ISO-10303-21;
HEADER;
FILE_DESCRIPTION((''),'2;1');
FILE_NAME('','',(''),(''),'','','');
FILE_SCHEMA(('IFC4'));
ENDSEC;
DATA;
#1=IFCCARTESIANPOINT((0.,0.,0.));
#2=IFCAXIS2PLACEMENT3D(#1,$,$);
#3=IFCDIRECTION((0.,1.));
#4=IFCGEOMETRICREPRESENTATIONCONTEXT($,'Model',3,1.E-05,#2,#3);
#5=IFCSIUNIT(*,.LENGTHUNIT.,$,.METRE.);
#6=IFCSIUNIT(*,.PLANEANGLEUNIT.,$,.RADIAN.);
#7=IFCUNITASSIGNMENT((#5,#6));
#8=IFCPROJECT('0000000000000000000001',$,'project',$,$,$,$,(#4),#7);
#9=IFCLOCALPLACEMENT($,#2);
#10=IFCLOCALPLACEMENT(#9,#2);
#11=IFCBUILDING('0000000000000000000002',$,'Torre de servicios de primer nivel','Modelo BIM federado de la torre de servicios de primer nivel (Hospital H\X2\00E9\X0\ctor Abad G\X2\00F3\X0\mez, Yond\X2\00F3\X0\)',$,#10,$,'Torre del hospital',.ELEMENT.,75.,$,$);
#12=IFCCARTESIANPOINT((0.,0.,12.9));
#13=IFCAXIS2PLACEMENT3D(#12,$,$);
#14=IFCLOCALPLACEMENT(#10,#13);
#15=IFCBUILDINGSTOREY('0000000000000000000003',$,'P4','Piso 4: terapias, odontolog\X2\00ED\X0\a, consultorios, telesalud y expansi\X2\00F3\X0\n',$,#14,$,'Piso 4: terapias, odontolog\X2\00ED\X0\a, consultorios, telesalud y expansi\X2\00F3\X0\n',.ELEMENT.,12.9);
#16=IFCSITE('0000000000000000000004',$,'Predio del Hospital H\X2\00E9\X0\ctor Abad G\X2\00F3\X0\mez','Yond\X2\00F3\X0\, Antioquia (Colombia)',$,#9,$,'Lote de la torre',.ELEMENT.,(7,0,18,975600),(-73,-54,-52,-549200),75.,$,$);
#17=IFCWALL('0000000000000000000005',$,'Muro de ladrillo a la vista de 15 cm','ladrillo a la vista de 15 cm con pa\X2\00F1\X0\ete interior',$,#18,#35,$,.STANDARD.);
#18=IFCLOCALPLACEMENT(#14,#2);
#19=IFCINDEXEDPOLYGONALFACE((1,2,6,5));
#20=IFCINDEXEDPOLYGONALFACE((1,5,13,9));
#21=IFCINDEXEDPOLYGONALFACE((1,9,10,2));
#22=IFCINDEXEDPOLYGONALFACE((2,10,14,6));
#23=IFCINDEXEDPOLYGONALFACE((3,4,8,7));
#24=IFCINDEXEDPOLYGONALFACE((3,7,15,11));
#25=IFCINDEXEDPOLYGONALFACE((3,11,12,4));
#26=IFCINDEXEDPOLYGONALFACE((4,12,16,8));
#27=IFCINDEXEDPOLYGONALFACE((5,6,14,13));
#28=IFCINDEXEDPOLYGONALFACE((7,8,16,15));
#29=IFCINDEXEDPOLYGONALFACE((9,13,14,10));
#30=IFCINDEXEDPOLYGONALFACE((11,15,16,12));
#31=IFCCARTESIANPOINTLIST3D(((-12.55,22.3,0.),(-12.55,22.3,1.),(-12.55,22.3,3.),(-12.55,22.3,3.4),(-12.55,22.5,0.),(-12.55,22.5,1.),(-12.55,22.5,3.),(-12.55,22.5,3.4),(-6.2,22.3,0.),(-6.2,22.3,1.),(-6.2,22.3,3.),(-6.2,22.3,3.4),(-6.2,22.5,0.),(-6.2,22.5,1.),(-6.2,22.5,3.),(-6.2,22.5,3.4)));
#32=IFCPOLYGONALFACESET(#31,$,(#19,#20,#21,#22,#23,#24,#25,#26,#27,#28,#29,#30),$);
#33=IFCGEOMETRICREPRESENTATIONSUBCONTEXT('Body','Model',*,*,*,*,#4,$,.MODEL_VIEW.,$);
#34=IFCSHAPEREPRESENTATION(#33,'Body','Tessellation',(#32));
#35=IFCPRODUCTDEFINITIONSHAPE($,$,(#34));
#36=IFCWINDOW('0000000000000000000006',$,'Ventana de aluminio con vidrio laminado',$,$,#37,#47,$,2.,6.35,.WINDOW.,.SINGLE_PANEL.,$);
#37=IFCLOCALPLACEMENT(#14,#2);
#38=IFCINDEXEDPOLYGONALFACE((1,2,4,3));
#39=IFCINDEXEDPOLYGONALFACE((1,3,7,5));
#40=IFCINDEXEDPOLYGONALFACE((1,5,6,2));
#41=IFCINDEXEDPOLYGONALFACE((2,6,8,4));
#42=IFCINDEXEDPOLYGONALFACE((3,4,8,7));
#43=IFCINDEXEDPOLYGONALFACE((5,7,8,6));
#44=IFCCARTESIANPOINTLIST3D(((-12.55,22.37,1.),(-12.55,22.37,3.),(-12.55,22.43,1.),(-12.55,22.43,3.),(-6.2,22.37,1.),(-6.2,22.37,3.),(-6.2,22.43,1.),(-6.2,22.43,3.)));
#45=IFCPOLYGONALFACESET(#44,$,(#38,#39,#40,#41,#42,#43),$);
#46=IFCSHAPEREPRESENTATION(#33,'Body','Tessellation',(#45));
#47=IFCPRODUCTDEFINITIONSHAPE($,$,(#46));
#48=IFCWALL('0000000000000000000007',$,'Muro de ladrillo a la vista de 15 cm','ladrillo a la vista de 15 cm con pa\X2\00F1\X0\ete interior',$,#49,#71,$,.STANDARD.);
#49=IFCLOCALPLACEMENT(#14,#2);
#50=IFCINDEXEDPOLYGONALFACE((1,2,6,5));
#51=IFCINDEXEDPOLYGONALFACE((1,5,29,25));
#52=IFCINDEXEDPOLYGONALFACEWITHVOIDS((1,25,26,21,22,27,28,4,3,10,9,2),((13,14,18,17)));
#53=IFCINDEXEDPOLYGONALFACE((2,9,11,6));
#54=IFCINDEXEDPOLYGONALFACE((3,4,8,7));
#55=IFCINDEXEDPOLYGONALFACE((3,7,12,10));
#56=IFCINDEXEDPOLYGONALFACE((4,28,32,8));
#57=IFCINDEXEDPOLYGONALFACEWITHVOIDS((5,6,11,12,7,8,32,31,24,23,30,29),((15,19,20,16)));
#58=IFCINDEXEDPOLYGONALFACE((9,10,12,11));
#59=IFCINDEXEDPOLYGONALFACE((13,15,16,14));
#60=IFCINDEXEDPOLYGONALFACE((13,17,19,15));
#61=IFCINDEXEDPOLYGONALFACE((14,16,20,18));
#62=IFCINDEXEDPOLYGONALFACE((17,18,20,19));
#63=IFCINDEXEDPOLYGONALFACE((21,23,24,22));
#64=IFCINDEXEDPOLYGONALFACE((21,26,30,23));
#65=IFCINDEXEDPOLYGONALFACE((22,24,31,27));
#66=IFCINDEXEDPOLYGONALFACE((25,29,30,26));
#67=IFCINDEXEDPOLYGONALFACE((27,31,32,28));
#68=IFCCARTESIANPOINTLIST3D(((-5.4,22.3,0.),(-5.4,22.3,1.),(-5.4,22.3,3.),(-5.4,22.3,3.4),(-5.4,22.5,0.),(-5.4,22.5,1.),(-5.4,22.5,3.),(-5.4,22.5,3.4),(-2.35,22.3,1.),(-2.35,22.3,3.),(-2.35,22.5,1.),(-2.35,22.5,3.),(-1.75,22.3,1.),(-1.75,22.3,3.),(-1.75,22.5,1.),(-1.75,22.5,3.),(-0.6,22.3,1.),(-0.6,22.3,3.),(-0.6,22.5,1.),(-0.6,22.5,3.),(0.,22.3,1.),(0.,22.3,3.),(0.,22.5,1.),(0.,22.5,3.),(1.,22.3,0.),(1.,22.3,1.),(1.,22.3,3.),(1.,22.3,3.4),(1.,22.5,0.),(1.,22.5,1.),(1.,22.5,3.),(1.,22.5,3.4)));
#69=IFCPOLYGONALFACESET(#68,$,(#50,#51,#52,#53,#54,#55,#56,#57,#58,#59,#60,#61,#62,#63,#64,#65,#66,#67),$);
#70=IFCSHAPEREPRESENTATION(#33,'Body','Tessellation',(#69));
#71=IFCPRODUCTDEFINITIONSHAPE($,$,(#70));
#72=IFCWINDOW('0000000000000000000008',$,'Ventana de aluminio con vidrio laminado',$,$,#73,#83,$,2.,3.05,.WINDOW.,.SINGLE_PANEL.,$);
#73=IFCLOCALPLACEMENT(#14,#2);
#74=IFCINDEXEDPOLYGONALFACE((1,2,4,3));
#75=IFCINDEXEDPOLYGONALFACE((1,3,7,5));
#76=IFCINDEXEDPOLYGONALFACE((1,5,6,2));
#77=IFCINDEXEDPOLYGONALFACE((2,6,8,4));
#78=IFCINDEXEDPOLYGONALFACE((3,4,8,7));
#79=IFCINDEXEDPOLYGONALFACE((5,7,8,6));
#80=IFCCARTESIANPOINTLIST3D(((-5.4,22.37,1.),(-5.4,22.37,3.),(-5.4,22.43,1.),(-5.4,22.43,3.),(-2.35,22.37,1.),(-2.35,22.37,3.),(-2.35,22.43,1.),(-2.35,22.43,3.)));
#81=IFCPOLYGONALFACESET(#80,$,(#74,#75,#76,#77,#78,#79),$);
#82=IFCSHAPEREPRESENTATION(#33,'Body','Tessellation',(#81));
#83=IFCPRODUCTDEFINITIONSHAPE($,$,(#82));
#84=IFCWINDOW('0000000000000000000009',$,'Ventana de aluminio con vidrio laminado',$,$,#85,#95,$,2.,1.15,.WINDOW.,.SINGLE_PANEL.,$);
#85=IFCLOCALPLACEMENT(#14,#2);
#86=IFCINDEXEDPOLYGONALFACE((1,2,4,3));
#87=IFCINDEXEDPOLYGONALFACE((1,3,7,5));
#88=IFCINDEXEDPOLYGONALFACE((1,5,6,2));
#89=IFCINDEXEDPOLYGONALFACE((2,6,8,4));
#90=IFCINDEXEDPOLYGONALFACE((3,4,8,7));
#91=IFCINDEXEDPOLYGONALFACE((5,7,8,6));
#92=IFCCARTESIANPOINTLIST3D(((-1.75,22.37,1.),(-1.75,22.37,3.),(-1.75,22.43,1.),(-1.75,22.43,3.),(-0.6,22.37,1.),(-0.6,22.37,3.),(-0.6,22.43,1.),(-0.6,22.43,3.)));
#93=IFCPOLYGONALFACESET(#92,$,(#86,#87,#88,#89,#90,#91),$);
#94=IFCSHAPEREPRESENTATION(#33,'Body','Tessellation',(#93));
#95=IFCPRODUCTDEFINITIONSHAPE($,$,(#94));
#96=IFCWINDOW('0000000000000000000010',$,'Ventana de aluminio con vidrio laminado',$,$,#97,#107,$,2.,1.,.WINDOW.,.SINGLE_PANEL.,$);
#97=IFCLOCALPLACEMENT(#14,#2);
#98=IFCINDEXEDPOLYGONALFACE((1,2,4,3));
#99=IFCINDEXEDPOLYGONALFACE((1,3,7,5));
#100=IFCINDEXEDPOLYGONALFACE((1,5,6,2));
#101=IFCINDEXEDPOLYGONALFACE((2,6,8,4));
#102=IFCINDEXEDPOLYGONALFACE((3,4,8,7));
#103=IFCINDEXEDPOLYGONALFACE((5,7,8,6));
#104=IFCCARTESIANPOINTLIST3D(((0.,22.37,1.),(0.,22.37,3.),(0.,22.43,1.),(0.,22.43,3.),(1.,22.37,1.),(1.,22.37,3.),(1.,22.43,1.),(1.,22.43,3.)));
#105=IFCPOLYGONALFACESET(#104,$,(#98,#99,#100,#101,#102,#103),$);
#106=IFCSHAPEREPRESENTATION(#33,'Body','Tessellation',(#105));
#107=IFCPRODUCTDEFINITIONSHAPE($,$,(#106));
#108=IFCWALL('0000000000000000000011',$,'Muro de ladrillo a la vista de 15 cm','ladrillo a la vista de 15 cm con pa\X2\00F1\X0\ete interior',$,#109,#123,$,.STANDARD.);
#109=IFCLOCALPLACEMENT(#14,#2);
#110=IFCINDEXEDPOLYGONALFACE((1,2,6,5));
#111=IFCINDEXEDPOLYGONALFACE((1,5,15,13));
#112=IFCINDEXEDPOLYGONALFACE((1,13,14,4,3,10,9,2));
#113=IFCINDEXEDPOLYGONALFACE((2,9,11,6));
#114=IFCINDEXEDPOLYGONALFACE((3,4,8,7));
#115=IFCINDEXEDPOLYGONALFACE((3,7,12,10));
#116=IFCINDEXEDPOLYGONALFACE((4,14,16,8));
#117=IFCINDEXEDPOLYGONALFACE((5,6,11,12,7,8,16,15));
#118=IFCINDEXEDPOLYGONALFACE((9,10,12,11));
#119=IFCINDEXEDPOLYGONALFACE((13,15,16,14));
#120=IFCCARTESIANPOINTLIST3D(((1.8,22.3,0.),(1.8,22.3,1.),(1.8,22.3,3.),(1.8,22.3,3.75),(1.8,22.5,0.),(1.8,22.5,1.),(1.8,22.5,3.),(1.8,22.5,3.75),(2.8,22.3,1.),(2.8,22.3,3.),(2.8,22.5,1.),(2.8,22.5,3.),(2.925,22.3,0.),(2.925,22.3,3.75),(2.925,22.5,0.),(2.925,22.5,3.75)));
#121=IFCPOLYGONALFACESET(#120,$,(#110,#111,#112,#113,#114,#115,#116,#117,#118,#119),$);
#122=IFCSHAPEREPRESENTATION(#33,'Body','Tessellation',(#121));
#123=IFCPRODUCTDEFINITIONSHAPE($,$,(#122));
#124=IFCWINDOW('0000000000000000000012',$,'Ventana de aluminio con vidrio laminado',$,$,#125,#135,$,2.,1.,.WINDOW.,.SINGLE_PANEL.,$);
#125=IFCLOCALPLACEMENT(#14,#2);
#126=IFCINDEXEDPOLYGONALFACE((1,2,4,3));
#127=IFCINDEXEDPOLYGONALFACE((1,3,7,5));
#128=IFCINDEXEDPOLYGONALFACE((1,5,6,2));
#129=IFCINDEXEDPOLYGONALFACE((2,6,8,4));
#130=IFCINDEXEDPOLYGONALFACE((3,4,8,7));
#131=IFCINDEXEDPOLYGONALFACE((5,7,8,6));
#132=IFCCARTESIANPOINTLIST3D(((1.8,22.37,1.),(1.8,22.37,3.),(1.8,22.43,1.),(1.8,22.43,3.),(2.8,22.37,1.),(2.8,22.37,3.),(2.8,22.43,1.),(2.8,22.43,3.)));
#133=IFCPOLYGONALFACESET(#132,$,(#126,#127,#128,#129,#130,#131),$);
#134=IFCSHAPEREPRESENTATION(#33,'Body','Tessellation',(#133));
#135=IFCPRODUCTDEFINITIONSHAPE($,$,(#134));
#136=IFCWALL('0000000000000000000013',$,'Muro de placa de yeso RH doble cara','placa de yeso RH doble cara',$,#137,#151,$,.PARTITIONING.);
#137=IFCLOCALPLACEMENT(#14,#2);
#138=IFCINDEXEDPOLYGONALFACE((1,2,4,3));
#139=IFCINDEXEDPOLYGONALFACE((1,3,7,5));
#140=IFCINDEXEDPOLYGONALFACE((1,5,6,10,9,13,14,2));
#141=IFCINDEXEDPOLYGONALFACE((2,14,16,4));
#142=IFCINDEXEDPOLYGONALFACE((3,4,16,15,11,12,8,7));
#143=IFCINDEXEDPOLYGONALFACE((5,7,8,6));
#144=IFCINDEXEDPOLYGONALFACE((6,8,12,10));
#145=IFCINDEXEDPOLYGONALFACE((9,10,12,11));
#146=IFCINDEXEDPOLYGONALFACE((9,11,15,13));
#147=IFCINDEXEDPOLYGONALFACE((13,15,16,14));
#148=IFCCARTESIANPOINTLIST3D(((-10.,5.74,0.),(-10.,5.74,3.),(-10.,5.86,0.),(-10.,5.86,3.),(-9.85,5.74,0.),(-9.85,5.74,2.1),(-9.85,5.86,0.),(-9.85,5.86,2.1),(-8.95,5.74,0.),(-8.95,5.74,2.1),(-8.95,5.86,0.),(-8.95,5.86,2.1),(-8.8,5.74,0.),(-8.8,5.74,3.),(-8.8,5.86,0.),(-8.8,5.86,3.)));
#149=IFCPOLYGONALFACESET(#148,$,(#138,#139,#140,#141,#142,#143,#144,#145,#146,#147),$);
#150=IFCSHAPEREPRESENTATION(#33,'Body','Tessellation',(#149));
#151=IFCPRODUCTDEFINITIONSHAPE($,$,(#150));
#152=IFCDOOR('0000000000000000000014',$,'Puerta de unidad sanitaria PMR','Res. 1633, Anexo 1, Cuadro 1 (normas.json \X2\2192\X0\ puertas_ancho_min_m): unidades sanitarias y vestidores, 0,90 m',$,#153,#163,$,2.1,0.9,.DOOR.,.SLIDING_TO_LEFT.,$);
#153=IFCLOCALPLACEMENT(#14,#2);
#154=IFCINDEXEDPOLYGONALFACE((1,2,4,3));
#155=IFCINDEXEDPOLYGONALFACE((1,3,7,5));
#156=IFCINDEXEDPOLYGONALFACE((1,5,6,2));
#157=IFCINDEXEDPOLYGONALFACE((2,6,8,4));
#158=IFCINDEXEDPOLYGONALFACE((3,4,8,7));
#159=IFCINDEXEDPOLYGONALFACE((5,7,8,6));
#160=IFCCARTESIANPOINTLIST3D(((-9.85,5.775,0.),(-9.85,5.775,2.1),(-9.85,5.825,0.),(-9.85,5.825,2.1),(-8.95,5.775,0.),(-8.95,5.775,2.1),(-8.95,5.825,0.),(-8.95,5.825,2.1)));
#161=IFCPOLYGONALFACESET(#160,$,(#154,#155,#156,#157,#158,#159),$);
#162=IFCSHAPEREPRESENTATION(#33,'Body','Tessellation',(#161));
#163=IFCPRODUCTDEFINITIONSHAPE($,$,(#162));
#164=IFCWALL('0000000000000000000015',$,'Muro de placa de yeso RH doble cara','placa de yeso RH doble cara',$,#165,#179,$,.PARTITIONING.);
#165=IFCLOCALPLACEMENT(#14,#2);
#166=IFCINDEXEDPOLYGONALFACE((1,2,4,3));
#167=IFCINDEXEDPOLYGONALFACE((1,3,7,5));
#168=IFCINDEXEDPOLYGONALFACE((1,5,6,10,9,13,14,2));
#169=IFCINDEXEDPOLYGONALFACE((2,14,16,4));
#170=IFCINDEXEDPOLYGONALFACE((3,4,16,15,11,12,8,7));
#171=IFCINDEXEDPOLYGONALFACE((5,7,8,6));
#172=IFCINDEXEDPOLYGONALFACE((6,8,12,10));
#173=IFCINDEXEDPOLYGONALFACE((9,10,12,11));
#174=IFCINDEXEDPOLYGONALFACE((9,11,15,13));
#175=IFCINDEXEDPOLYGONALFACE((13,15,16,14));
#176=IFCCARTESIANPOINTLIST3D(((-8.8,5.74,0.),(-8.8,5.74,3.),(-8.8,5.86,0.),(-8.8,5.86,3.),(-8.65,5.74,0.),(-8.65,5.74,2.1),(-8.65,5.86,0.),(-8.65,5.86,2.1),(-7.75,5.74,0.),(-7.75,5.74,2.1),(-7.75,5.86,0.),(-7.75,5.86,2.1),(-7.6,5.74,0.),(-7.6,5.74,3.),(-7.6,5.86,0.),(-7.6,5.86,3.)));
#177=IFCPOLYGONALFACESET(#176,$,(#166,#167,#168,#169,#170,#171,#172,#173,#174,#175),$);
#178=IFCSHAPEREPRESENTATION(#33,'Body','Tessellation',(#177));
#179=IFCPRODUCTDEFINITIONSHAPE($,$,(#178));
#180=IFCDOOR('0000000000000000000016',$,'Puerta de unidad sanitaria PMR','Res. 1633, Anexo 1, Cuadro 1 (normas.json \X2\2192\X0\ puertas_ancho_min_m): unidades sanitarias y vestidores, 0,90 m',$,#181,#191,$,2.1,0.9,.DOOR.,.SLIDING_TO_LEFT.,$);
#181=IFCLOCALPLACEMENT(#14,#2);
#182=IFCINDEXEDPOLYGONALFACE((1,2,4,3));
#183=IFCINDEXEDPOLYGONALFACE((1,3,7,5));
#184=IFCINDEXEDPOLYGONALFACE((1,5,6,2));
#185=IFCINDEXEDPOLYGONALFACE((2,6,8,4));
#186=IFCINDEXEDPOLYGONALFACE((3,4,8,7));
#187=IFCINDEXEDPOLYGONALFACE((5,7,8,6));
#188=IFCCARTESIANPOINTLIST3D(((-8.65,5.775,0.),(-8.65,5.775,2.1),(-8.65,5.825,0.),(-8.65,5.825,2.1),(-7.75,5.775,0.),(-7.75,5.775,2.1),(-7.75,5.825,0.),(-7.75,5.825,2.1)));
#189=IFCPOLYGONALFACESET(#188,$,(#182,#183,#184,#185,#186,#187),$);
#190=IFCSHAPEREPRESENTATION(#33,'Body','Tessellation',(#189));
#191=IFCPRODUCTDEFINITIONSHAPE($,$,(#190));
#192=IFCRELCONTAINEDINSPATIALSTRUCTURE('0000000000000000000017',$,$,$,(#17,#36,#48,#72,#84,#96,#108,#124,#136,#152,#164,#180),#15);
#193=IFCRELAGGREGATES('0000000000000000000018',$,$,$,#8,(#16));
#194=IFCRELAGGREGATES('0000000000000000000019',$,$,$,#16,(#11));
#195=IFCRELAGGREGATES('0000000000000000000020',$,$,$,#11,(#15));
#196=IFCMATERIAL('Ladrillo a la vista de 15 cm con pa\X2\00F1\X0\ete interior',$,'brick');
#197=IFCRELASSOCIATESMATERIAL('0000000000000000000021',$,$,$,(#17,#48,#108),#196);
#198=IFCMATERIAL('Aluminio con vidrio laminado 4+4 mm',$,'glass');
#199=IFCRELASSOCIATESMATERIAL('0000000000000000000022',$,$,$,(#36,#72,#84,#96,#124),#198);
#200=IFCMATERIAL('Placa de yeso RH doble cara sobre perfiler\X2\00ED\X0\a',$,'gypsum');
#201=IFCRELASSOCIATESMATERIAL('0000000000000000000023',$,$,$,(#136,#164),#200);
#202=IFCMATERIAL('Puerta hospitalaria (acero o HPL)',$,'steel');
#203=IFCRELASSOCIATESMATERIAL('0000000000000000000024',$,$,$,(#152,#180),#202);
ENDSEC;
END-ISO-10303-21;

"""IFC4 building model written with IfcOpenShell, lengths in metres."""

from ifc_helpers import new_model, si_unit, direction, frame, origin, place, context, subcontext, project, spatial, rectangle, extrude, material, element, fill, save


model = new_model("IFC4")

# Units and contexts
model_context = context("Model", 3, precision=1e-05, world=origin(), true_north=direction((0.0, 1.0)))
body_context = subcontext(model_context, "Body", "Model", "MODEL_VIEW")
ifc_project = project(units=[si_unit("LENGTHUNIT", "METRE"), si_unit("PLANEANGLEUNIT", "RADIAN")], contexts=[model_context])

# Site, building, storey
site_placement = place(None, origin())
site = spatial("IfcSite", under=ifc_project, at=site_placement, Name="Predio del Hospital Héctor Abad Gómez", Description="Yondó, Antioquia (Colombia)", LongName="Lote de la torre", CompositionType="ELEMENT", RefLatitude=(7, 0, 18, 975600), RefLongitude=(-73, -54, -52, -549200), RefElevation=75.0)
building_placement = place(site_placement, origin())
building = spatial("IfcBuilding", under=site, at=building_placement, Name="Torre de servicios de primer nivel", Description="Modelo BIM federado de la torre de servicios de primer nivel (Hospital Héctor Abad Gómez, Yondó)", LongName="Torre del hospital", CompositionType="ELEMENT", ElevationOfRefHeight=75.0)
placement = place(building_placement, frame((0.0, 0.0, 12.9)))
storey = spatial("IfcBuildingStorey", under=building, at=placement, Name="P4", Description="Piso 4: terapias, odontología, consultorios, telesalud y expansión", LongName="Piso 4: terapias, odontología, consultorios, telesalud y expansión", CompositionType="ELEMENT", Elevation=12.9)

# Shared definitions
ifc_material_1 = material(Name="Puerta hospitalaria (acero o HPL)", Category="steel")

# Shared definitions
ifc_material_2 = material(Name="Placa de yeso RH doble cara sobre perfilería", Category="gypsum")

# Wall, opening, window
ifc_material_3 = material(Name="Ladrillo a la vista de 15 cm con pañete interior", Category="brick")
wall_1 = element("IfcWall", 1, at=placement, inside=storey, material=ifc_material_3, Name="Muro de ladrillo a la vista de 15 cm", Description="ladrillo a la vista de 15 cm con pañete interior", PredefinedType="STANDARD", context=body_context, shape_type="SweptSolid", body=[
    extrude(rectangle(XDim=6.35, YDim=0.2), frame((-9.375, 22.4, 0.0)), (0.0, 0.0, 1.0), 3.4),
])
opening_1 = element("IfcOpeningElement", 2, at=placement, cuts=wall_1, PredefinedType="OPENING", context=body_context, shape_type="SweptSolid", body=[
    extrude(rectangle(XDim=6.35, YDim=0.3), frame((-9.375, 22.4, 1.0)), (0.0, 0.0, 1.0), 2.0),
])
ifc_material_4 = material(Name="Aluminio con vidrio laminado 4+4 mm", Category="glass")
window_1 = element("IfcWindow", 3, at=placement, inside=storey, material=ifc_material_4, Name="Ventana de aluminio con vidrio laminado", OverallHeight=2.0, OverallWidth=6.35, PartitioningType="SINGLE_PANEL", PredefinedType="WINDOW", context=body_context, shape_type="SweptSolid", body=[
    extrude(rectangle(XDim=6.35, YDim=0.06), frame((-9.375, 22.4, 1.0)), (0.0, 0.0, 1.0), 2.0),
])
fill(opening_1, window_1)

# Wall, openings, windows
wall_2 = element("IfcWall", 4, at=placement, inside=storey, material=ifc_material_3, Name="Muro de ladrillo a la vista de 15 cm", Description="ladrillo a la vista de 15 cm con pañete interior", PredefinedType="STANDARD", context=body_context, shape_type="SweptSolid", body=[
    extrude(rectangle(XDim=6.4, YDim=0.2), frame((-2.2, 22.4, 0.0)), (0.0, 0.0, 1.0), 3.4),
])
opening_2 = element("IfcOpeningElement", 5, at=placement, cuts=wall_2, PredefinedType="OPENING", context=body_context, shape_type="SweptSolid", body=[
    extrude(rectangle(XDim=3.05, YDim=0.3), frame((-3.875, 22.4, 1.0)), (0.0, 0.0, 1.0), 2.0),
])
opening_3 = element("IfcOpeningElement", 6, at=placement, cuts=wall_2, PredefinedType="OPENING", context=body_context, shape_type="SweptSolid", body=[
    extrude(rectangle(XDim=1.15, YDim=0.3), frame((-1.175, 22.4, 1.0)), (0.0, 0.0, 1.0), 2.0),
])
opening_4 = element("IfcOpeningElement", 7, at=placement, cuts=wall_2, PredefinedType="OPENING", context=body_context, shape_type="SweptSolid", body=[
    extrude(rectangle(XDim=1.0, YDim=0.3), frame((0.5, 22.4, 1.0)), (0.0, 0.0, 1.0), 2.0),
])
window_2 = element("IfcWindow", 8, at=placement, inside=storey, material=ifc_material_4, Name="Ventana de aluminio con vidrio laminado", OverallHeight=2.0, OverallWidth=3.05, PartitioningType="SINGLE_PANEL", PredefinedType="WINDOW", context=body_context, shape_type="SweptSolid", body=[
    extrude(rectangle(XDim=3.05, YDim=0.06), frame((-3.875, 22.4, 1.0)), (0.0, 0.0, 1.0), 2.0),
])
fill(opening_2, window_2)
window_3 = element("IfcWindow", 9, at=placement, inside=storey, material=ifc_material_4, Name="Ventana de aluminio con vidrio laminado", OverallHeight=2.0, OverallWidth=1.15, PartitioningType="SINGLE_PANEL", PredefinedType="WINDOW", context=body_context, shape_type="SweptSolid", body=[
    extrude(rectangle(XDim=1.15, YDim=0.06), frame((-1.175, 22.4, 1.0)), (0.0, 0.0, 1.0), 2.0),
])
fill(opening_3, window_3)
window_4 = element("IfcWindow", 10, at=placement, inside=storey, material=ifc_material_4, Name="Ventana de aluminio con vidrio laminado", OverallHeight=2.0, OverallWidth=1.0, PartitioningType="SINGLE_PANEL", PredefinedType="WINDOW", context=body_context, shape_type="SweptSolid", body=[
    extrude(rectangle(XDim=1.0, YDim=0.06), frame((0.5, 22.4, 1.0)), (0.0, 0.0, 1.0), 2.0),
])
fill(opening_4, window_4)

# Wall, opening, window
wall_3 = element("IfcWall", 11, at=placement, inside=storey, material=ifc_material_3, Name="Muro de ladrillo a la vista de 15 cm", Description="ladrillo a la vista de 15 cm con pañete interior", PredefinedType="STANDARD", context=body_context, shape_type="SweptSolid", body=[
    extrude(rectangle(XDim=1.125, YDim=0.2), frame((2.3625, 22.4, 0.0)), (0.0, 0.0, 1.0), 3.75),
])
opening_5 = element("IfcOpeningElement", 12, at=placement, cuts=wall_3, PredefinedType="OPENING", context=body_context, shape_type="SweptSolid", body=[
    extrude(rectangle(XDim=1.0, YDim=0.3), frame((2.3, 22.4, 1.0)), (0.0, 0.0, 1.0), 2.0),
])
window_5 = element("IfcWindow", 13, at=placement, inside=storey, material=ifc_material_4, Name="Ventana de aluminio con vidrio laminado", OverallHeight=2.0, OverallWidth=1.0, PartitioningType="SINGLE_PANEL", PredefinedType="WINDOW", context=body_context, shape_type="SweptSolid", body=[
    extrude(rectangle(XDim=1.0, YDim=0.06), frame((2.3, 22.4, 1.0)), (0.0, 0.0, 1.0), 2.0),
])
fill(opening_5, window_5)

# Walls, openings, doors
wall_4 = element("IfcWall", 14, at=placement, inside=storey, material=ifc_material_2, Name="Muro de placa de yeso RH doble cara", Description="placa de yeso RH doble cara", PredefinedType="PARTITIONING", context=body_context, shape_type="SweptSolid", body=[
    extrude(rectangle(XDim=1.2, YDim=0.12), frame((-9.4, 5.8, 0.0)), (0.0, 0.0, 1.0), 3.0),
])
opening_6 = element("IfcOpeningElement", 15, at=placement, cuts=wall_4, PredefinedType="OPENING", context=body_context, shape_type="SweptSolid", body=[
    extrude(rectangle(XDim=0.9, YDim=0.22), frame((-9.4, 5.8, 0.0)), (0.0, 0.0, 1.0), 2.1),
])
door_1 = element("IfcDoor", 16, at=placement, inside=storey, material=ifc_material_1, Name="Puerta de unidad sanitaria PMR", Description="Res. 1633, Anexo 1, Cuadro 1 (normas.json → puertas_ancho_min_m): unidades sanitarias y vestidores, 0,90 m", OperationType="SLIDING_TO_LEFT", OverallHeight=2.1, OverallWidth=0.9, PredefinedType="DOOR", context=body_context, shape_type="SweptSolid", body=[
    extrude(rectangle(XDim=0.9, YDim=0.05), frame((-9.4, 5.8, 0.0)), (0.0, 0.0, 1.0), 2.1),
])
fill(opening_6, door_1)
wall_5 = element("IfcWall", 17, at=placement, inside=storey, material=ifc_material_2, Name="Muro de placa de yeso RH doble cara", Description="placa de yeso RH doble cara", PredefinedType="PARTITIONING", context=body_context, shape_type="SweptSolid", body=[
    extrude(rectangle(XDim=1.2, YDim=0.12), frame((-8.2, 5.8, 0.0)), (0.0, 0.0, 1.0), 3.0),
])
opening_7 = element("IfcOpeningElement", 18, at=placement, cuts=wall_5, PredefinedType="OPENING", context=body_context, shape_type="SweptSolid", body=[
    extrude(rectangle(XDim=0.9, YDim=0.22), frame((-8.2, 5.8, 0.0)), (0.0, 0.0, 1.0), 2.1),
])
door_2 = element("IfcDoor", 19, at=placement, inside=storey, material=ifc_material_1, Name="Puerta de unidad sanitaria PMR", Description="Res. 1633, Anexo 1, Cuadro 1 (normas.json → puertas_ancho_min_m): unidades sanitarias y vestidores, 0,90 m", OperationType="SLIDING_TO_LEFT", OverallHeight=2.1, OverallWidth=0.9, PredefinedType="DOOR", context=body_context, shape_type="SweptSolid", body=[
    extrude(rectangle(XDim=0.9, YDim=0.05), frame((-8.2, 5.8, 0.0)), (0.0, 0.0, 1.0), 2.1),
])
fill(opening_7, door_2)

save(model, "model.ifc")
